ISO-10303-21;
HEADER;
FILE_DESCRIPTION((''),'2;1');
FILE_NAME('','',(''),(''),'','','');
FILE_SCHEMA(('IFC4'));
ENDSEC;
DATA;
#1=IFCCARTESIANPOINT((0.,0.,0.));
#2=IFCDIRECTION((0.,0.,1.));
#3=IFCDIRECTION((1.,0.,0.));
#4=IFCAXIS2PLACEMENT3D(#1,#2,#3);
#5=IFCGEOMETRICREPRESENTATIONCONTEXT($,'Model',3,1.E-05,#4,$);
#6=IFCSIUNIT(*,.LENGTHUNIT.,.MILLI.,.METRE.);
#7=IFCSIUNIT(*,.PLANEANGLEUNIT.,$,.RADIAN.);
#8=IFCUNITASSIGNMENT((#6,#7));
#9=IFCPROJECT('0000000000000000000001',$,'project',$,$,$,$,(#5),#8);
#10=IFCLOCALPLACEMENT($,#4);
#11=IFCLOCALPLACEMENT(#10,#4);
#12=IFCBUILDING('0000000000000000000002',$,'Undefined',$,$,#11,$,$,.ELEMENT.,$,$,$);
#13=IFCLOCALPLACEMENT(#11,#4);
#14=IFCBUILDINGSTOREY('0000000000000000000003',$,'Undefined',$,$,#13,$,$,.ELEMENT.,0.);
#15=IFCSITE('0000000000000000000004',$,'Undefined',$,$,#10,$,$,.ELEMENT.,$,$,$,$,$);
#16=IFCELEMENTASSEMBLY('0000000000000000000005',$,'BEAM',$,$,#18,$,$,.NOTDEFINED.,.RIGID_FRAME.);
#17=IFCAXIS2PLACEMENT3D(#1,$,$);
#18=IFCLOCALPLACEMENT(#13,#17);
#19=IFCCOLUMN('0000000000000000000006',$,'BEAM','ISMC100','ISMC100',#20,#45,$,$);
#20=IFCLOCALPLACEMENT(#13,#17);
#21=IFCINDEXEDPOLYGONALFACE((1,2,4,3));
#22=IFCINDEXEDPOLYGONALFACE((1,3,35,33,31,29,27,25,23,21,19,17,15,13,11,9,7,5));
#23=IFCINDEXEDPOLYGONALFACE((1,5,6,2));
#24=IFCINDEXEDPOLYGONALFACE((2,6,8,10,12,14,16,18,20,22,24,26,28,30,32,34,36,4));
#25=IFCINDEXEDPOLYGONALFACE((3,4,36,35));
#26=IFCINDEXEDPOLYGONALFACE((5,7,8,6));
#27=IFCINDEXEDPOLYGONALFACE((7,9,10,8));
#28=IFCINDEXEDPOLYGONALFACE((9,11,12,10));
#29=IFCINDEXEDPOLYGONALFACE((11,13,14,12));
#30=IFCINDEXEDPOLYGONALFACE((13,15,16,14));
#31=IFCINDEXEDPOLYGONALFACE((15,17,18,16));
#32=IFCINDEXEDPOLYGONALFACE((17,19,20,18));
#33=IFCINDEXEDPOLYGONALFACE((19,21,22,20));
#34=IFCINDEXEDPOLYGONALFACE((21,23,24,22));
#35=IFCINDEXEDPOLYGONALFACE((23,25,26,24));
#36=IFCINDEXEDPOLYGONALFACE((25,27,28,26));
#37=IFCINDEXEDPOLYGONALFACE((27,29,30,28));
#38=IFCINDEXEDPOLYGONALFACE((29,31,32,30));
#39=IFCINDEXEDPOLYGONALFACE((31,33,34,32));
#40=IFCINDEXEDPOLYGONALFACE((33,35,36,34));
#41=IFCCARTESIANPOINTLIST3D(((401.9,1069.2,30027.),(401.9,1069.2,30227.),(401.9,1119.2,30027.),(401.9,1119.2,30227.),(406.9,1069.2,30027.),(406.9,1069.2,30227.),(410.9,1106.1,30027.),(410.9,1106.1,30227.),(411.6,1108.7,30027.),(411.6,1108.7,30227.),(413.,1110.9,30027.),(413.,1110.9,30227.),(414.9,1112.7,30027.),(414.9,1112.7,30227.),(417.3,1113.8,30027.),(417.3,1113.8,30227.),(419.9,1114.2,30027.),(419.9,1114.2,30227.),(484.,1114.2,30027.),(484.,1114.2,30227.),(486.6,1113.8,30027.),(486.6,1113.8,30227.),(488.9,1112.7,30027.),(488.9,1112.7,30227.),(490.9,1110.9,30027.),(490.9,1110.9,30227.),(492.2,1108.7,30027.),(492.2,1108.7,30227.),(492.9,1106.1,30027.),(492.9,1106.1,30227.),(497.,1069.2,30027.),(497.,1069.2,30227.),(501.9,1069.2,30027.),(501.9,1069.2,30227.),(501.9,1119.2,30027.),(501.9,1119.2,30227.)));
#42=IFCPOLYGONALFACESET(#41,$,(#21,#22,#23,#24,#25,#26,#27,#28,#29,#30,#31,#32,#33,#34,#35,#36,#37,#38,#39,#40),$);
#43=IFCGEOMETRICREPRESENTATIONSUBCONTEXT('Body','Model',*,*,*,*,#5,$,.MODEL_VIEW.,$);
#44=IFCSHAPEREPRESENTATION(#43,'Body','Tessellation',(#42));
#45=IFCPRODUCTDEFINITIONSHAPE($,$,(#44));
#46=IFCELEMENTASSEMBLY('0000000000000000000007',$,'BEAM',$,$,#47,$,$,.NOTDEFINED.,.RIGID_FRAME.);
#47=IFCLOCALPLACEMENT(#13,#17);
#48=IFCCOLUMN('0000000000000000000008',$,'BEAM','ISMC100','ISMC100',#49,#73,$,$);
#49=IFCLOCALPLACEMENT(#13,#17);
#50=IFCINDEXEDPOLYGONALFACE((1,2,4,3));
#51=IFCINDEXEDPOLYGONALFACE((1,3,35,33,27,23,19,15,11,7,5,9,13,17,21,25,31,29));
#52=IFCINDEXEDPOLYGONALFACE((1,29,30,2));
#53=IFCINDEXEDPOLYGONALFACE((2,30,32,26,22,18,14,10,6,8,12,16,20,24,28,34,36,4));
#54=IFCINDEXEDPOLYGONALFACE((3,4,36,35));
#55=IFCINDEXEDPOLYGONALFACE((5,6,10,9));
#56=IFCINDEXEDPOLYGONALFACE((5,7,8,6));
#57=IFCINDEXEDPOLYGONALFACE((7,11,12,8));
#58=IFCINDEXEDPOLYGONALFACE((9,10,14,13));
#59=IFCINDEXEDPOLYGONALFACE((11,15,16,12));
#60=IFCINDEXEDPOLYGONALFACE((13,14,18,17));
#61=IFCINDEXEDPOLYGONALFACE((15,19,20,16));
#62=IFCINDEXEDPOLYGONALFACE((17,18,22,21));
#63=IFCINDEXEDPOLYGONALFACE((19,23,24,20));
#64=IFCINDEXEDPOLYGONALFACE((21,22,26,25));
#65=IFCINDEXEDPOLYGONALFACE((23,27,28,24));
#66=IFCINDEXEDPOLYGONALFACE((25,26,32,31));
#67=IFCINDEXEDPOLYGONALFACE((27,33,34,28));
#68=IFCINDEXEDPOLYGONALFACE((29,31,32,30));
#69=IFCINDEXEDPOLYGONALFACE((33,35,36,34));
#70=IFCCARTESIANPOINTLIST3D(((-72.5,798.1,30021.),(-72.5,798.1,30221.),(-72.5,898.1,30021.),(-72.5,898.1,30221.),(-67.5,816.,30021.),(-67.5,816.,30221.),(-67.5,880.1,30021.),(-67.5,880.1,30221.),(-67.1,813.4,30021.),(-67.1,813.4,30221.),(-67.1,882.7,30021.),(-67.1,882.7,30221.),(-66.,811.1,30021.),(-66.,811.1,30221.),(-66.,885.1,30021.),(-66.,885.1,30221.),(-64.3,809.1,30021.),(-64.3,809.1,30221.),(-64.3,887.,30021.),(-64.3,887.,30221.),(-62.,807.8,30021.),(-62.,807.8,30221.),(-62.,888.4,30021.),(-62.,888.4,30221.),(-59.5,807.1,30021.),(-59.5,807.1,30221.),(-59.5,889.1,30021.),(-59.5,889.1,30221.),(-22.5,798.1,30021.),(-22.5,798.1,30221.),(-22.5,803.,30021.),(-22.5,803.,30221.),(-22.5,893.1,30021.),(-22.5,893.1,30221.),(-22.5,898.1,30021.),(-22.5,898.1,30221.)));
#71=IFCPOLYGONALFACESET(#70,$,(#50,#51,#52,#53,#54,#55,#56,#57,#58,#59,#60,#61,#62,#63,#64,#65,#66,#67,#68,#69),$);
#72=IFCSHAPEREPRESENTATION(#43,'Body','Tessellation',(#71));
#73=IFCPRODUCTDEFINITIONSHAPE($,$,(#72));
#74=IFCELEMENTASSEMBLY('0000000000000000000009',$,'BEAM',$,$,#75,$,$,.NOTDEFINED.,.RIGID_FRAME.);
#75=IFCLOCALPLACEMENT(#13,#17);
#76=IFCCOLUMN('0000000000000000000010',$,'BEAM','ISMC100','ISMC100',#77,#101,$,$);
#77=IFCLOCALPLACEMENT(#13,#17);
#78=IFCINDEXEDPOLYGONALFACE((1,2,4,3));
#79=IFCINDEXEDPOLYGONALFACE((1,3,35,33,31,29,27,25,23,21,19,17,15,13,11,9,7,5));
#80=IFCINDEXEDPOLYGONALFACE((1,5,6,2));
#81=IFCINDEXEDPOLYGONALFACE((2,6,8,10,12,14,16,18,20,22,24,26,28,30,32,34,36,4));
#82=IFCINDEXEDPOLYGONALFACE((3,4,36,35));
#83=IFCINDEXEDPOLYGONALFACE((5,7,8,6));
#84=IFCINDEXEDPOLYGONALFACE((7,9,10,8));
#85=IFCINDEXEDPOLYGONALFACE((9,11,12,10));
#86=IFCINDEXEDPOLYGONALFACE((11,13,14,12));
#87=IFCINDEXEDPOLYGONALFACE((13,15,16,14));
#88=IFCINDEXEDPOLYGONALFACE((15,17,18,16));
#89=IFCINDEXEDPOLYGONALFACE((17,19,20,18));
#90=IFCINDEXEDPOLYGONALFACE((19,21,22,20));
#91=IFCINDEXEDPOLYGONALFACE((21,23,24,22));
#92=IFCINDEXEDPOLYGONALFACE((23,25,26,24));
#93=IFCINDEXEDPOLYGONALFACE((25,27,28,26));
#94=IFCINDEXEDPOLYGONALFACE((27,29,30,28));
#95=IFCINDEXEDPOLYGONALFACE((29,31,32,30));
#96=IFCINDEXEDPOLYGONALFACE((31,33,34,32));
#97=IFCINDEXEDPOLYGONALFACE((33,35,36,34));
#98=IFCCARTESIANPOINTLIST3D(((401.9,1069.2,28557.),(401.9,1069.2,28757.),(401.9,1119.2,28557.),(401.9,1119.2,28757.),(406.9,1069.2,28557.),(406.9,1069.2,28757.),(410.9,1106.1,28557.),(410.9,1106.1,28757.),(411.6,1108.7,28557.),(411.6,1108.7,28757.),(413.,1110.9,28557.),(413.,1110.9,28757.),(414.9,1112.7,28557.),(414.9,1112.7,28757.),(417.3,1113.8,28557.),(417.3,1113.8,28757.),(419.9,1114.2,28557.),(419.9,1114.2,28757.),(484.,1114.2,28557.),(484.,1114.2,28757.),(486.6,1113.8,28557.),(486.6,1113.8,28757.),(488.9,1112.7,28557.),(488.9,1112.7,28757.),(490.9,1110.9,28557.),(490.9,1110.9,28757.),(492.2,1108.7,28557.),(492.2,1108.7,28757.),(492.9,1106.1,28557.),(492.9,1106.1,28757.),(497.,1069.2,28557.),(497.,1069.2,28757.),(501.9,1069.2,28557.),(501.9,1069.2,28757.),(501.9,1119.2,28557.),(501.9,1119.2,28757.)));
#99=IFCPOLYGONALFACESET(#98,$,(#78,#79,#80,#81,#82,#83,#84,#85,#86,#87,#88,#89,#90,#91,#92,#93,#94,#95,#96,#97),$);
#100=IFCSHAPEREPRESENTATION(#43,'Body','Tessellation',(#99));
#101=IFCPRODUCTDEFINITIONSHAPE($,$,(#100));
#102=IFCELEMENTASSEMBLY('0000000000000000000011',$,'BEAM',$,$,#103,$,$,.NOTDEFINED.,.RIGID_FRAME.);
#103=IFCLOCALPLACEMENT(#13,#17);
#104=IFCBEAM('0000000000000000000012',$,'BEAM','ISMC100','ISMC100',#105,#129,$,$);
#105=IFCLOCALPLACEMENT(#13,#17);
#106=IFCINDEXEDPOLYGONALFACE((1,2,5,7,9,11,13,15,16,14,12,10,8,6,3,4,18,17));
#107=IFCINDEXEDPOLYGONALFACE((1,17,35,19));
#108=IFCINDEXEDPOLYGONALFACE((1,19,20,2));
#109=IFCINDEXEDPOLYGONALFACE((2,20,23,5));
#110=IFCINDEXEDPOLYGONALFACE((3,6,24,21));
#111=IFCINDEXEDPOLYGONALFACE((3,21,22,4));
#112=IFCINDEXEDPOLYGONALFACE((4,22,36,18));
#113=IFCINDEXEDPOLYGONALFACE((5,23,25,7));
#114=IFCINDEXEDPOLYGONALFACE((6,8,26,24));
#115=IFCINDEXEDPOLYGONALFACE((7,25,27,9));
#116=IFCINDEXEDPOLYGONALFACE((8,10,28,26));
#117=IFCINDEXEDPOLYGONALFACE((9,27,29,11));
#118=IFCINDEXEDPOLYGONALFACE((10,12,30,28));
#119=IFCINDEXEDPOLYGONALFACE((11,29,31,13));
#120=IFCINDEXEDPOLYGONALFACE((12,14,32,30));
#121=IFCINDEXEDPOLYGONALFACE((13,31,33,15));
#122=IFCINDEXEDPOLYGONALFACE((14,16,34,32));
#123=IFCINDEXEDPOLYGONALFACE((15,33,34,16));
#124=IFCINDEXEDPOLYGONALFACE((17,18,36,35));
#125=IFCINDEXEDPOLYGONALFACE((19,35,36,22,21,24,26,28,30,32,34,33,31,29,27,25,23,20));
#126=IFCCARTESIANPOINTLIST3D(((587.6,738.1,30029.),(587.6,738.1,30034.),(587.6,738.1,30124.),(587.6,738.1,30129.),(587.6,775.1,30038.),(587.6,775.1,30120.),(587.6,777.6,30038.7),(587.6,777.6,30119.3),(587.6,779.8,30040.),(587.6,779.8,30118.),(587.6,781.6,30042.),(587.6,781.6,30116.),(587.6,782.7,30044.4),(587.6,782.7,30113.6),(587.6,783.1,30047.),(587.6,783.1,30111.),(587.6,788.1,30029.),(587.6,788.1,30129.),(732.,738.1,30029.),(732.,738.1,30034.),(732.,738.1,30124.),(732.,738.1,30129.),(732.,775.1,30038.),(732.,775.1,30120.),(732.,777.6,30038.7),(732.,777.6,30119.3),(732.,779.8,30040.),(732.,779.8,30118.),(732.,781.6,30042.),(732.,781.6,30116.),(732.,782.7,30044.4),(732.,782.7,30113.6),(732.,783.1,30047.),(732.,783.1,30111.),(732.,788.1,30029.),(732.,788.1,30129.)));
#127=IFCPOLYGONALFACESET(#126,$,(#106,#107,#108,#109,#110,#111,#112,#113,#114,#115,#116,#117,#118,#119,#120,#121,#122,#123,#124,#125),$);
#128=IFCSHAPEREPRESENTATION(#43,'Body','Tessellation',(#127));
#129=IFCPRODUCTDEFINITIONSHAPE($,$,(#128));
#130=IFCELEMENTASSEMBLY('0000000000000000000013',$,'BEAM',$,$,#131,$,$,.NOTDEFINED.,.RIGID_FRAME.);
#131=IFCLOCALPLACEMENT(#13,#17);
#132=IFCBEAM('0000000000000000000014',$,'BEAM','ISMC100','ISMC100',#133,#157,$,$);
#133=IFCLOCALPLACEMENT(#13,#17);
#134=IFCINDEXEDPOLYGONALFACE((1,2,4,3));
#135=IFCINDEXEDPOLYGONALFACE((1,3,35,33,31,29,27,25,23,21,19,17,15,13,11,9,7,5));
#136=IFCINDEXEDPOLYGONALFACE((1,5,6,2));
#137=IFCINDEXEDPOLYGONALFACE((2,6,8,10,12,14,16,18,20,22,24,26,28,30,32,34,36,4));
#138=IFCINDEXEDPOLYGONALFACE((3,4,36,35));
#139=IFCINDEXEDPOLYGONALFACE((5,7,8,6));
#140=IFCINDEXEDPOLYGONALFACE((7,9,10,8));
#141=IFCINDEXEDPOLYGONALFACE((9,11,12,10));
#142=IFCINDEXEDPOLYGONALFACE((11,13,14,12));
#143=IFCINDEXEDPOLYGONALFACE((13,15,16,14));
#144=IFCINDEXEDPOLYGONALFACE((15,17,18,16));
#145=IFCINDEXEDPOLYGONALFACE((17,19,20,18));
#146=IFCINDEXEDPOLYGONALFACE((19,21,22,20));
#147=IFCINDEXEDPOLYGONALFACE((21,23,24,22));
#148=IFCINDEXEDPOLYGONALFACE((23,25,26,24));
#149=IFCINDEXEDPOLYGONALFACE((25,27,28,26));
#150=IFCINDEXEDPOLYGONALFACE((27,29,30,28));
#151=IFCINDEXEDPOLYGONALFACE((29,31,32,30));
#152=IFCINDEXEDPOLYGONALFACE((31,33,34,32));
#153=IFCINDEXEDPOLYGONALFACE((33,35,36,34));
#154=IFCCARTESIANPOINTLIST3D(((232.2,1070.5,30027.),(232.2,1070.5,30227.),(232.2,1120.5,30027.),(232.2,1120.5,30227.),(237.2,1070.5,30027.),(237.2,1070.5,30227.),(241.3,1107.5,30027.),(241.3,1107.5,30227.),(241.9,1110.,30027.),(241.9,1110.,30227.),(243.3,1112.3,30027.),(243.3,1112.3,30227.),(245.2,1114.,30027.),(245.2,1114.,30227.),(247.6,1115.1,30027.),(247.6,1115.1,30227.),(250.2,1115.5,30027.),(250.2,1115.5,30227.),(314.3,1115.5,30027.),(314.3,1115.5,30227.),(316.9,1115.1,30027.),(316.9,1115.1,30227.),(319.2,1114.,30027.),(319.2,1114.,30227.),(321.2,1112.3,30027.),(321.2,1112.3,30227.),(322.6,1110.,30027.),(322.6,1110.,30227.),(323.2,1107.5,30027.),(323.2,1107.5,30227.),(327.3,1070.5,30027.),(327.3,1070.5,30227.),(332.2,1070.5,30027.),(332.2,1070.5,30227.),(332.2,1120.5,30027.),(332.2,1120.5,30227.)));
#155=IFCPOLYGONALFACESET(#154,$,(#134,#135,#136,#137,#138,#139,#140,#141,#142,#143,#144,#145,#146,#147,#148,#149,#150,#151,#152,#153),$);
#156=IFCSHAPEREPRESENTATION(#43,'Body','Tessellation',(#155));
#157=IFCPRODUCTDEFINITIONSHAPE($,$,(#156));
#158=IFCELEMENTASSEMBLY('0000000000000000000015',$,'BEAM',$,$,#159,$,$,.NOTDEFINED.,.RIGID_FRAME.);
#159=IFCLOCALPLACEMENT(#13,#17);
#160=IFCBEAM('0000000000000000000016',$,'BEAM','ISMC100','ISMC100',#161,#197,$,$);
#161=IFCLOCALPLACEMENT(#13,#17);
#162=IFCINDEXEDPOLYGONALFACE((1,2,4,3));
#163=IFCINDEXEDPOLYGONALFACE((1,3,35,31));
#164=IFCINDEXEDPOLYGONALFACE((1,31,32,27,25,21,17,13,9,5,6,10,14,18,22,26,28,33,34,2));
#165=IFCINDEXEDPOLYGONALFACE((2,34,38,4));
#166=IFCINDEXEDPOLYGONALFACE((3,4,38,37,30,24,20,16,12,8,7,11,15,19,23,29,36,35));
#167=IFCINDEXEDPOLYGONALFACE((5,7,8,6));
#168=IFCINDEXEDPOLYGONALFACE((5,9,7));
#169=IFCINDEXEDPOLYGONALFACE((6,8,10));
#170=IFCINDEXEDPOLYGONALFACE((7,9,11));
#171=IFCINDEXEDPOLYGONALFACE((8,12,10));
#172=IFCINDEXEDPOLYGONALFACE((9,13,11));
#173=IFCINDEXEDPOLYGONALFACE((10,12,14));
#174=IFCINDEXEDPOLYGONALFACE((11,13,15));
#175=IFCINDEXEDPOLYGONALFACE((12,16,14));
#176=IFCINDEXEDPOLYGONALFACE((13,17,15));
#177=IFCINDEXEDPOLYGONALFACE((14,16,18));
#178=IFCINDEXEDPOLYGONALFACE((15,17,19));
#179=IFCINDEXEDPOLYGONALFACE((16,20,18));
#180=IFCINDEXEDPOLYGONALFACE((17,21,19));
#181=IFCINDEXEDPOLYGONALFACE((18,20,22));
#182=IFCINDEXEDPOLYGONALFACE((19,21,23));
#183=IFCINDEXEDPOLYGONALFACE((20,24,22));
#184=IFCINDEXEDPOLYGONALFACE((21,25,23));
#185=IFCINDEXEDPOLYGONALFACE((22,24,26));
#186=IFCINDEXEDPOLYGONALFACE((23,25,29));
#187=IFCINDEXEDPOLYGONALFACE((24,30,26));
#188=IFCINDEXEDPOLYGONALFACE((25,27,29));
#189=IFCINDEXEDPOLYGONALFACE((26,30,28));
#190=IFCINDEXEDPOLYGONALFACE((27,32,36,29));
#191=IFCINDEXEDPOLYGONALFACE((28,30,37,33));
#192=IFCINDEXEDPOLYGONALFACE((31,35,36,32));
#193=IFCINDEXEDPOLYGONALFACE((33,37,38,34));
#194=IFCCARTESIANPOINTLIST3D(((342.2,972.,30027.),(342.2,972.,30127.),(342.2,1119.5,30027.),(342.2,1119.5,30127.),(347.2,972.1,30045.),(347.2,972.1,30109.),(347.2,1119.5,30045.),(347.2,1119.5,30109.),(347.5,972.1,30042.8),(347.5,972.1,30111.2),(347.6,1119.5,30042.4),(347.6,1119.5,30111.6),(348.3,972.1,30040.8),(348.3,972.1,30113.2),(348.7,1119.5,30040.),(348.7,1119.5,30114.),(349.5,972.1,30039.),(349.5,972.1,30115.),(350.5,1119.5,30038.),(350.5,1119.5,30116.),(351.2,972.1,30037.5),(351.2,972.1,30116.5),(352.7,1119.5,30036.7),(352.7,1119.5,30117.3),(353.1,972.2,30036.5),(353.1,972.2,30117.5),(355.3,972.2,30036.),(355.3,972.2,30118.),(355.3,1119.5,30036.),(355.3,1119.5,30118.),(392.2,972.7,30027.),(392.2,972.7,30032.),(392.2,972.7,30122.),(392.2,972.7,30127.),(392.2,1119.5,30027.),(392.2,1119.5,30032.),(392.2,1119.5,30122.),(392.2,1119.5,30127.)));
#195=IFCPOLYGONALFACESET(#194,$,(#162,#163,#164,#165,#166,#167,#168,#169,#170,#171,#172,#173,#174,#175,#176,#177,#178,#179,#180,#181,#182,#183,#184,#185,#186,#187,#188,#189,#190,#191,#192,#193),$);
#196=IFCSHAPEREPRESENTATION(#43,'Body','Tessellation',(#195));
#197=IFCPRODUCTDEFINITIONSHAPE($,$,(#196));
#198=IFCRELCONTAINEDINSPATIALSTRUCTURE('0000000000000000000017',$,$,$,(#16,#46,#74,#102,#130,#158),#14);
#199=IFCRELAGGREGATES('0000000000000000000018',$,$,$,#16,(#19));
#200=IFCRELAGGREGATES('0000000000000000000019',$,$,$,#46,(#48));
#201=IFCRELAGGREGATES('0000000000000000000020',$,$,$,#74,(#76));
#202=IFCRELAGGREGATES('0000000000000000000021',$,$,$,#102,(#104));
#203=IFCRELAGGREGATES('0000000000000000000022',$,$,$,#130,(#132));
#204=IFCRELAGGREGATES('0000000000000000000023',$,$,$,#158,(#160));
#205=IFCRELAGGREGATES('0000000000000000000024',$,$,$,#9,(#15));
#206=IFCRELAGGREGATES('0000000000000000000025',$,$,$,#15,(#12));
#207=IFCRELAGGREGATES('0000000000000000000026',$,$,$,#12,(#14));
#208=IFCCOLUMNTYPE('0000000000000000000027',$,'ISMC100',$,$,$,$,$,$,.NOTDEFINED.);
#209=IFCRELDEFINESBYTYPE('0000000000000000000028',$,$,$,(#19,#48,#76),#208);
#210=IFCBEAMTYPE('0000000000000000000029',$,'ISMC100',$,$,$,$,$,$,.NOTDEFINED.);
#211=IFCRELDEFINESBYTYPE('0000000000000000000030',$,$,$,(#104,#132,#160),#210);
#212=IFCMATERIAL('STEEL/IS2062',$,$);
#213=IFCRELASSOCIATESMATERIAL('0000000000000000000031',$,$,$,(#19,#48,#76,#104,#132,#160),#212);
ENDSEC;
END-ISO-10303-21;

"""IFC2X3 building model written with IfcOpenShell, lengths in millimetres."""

from ifc_helpers import new_model, si_unit, frame, origin_with_axes, origin_2d_with_axis, place, context, subcontext, project, spatial, u_section, extrude, clip, halfspace, material, type_object, element, aggregate, save


model = new_model("IFC2X3")

# Units and contexts
model_context = context("Model", 3, precision=1e-05, world=origin_with_axes())
body_context = subcontext(model_context, "Body", "Model", "MODEL_VIEW")
ifc_project = project(units=[si_unit("LENGTHUNIT", "METRE", prefix="MILLI"), si_unit("PLANEANGLEUNIT", "RADIAN")], contexts=[model_context])

# Site, building, storey
site_placement = place(None, origin_with_axes())
site = spatial("IfcSite", under=ifc_project, at=site_placement, Name="Undefined", CompositionType="ELEMENT")
building_placement = place(site_placement, origin_with_axes())
building = spatial("IfcBuilding", under=site, at=building_placement, Name="Undefined", CompositionType="ELEMENT")
storey_placement = place(building_placement, origin_with_axes())
storey = spatial("IfcBuildingStorey", under=building, at=storey_placement, Name="Undefined", CompositionType="ELEMENT", Elevation=0.0)

# Element assemblies, columns
assembly_1_placement = place(storey_placement, origin_with_axes())
assembly_1 = element("IfcElementAssembly", 1, at=assembly_1_placement, inside=storey, Name="BEAM", AssemblyPlace="NOTDEFINED", PredefinedType="RIGID_FRAME")
ifc_material = material(Name="STEEL/IS2062")
column_type_1 = type_object("IfcColumnType", Name="ISMC100", PredefinedType="NOTDEFINED")
column_1_placement = place(assembly_1_placement, frame((451.9, 1094.2, 30027.0), z_axis=(0.0, 0.0, 1.0), x_axis=(-1.0, 0.0, 0.0)))
column_1 = element("IfcColumn", 2, at=column_1_placement, type_object=column_type_1, material=ifc_material, Name="BEAM", Description="ISMC100", ObjectType="ISMC100", context=body_context, shape_type="SweptSolid", body=[
    extrude(u_section(Depth=100.0, FlangeWidth=50.0, WebThickness=5.0, FlangeThickness=7.7, FilletRadius=9.0, FlangeSlope=0.10956, at=origin_2d_with_axis()), frame((0.0, 0.0, 200.0), z_axis=(0.0, 0.0, -1.0), x_axis=(0.0, 1.0, 0.0)), (0.0, 0.0, 1.0), 200.0),
])
aggregate(assembly_1, [column_1])
assembly_2_placement = place(storey_placement, origin_with_axes())
assembly_2 = element("IfcElementAssembly", 3, at=assembly_2_placement, inside=storey, Name="BEAM", AssemblyPlace="NOTDEFINED", PredefinedType="RIGID_FRAME")
column_2_placement = place(assembly_2_placement, frame((-47.5, 848.1, 30021.0), z_axis=(0.0, 0.0, 1.0), x_axis=(0.0, -1.0, 0.0)))
column_2 = element("IfcColumn", 4, at=column_2_placement, type_object=column_type_1, material=ifc_material, Name="BEAM", Description="ISMC100", ObjectType="ISMC100", context=body_context, shape_type="SweptSolid", body=[
    extrude(u_section(Depth=100.0, FlangeWidth=50.0, WebThickness=5.0, FlangeThickness=7.7, FilletRadius=9.0, FlangeSlope=0.10956, at=origin_2d_with_axis()), frame((0.0, 0.0, 200.0), z_axis=(0.0, 0.0, -1.0), x_axis=(0.0, 1.0, 0.0)), (0.0, 0.0, 1.0), 200.0),
])
aggregate(assembly_2, [column_2])
assembly_3_placement = place(storey_placement, origin_with_axes())
assembly_3 = element("IfcElementAssembly", 5, at=assembly_3_placement, inside=storey, Name="BEAM", AssemblyPlace="NOTDEFINED", PredefinedType="RIGID_FRAME")
column_3_placement = place(assembly_3_placement, frame((451.9, 1094.2, 28557.0), z_axis=(0.0, 0.0, 1.0), x_axis=(-1.0, 0.0, 0.0)))
column_3 = element("IfcColumn", 6, at=column_3_placement, type_object=column_type_1, material=ifc_material, Name="BEAM", Description="ISMC100", ObjectType="ISMC100", context=body_context, shape_type="SweptSolid", body=[
    extrude(u_section(Depth=100.0, FlangeWidth=50.0, WebThickness=5.0, FlangeThickness=7.7, FilletRadius=9.0, FlangeSlope=0.10956, at=origin_2d_with_axis()), frame((0.0, 0.0, 200.0), z_axis=(0.0, 0.0, -1.0), x_axis=(0.0, 1.0, 0.0)), (0.0, 0.0, 1.0), 200.0),
])
aggregate(assembly_3, [column_3])

# Element assemblies, beams
assembly_4_placement = place(storey_placement, origin_with_axes())
assembly_4 = element("IfcElementAssembly", 7, at=assembly_4_placement, inside=storey, Name="BEAM", AssemblyPlace="NOTDEFINED", PredefinedType="RIGID_FRAME")
beam_type_1 = type_object("IfcBeamType", Name="ISMC100", PredefinedType="NOTDEFINED")
beam_1_placement = place(assembly_4_placement, frame((732.0, 763.1, 30079.0), z_axis=(0.0, 0.0, -1.0), x_axis=(-1.0, 0.0, 0.0)))
beam_1 = element("IfcBeam", 8, at=beam_1_placement, type_object=beam_type_1, material=ifc_material, Name="BEAM", Description="ISMC100", ObjectType="ISMC100", context=body_context, shape_type="SweptSolid", body=[
    extrude(u_section(Depth=100.0, FlangeWidth=50.0, WebThickness=5.0, FlangeThickness=7.7, FilletRadius=9.0, FlangeSlope=0.10956, at=origin_2d_with_axis()), frame((144.4, 0.0, 0.0), z_axis=(-1.0, 0.0, 0.0), x_axis=(0.0, -1.0, 0.0)), (0.0, 0.0, 1.0), 144.4),
])
aggregate(assembly_4, [beam_1])
assembly_5_placement = place(storey_placement, origin_with_axes())
assembly_5 = element("IfcElementAssembly", 9, at=assembly_5_placement, inside=storey, Name="BEAM", AssemblyPlace="NOTDEFINED", PredefinedType="RIGID_FRAME")
beam_2_placement = place(assembly_5_placement, frame((282.2, 1095.5, 30227.0), z_axis=(1.0, 0.0, 0.0), x_axis=(0.0, 0.0, -1.0)))
beam_2 = element("IfcBeam", 10, at=beam_2_placement, type_object=beam_type_1, material=ifc_material, Name="BEAM", Description="ISMC100", ObjectType="ISMC100", context=body_context, shape_type="SweptSolid", body=[
    extrude(u_section(Depth=100.0, FlangeWidth=50.0, WebThickness=5.0, FlangeThickness=7.7, FilletRadius=9.0, FlangeSlope=0.10956, at=origin_2d_with_axis()), frame((200.0, 0.0, 0.0), z_axis=(-1.0, 0.0, 0.0), x_axis=(0.0, -1.0, 0.0)), (0.0, 0.0, 1.0), 200.0),
])
aggregate(assembly_5, [beam_2])
assembly_6_placement = place(storey_placement, origin_with_axes())
assembly_6 = element("IfcElementAssembly", 11, at=assembly_6_placement, inside=storey, Name="BEAM", AssemblyPlace="NOTDEFINED", PredefinedType="RIGID_FRAME")
beam_3_placement = place(assembly_6_placement, frame((367.2, 1119.5, 30077.0), z_axis=(0.0, 0.0, -1.0), x_axis=(0.0, -1.0, 0.0)))
beam_3 = element("IfcBeam", 12, at=beam_3_placement, type_object=beam_type_1, material=ifc_material, Name="BEAM", Description="ISMC100", ObjectType="ISMC100", context=body_context, shape_type="Clipping", body=[
    clip(extrude(u_section(Depth=100.0, FlangeWidth=50.0, WebThickness=5.0, FlangeThickness=7.7, FilletRadius=9.0, FlangeSlope=0.10956, at=origin_2d_with_axis()), frame((147.5, 0.0, 0.0), z_axis=(-1.0, 0.0, 0.0), x_axis=(0.0, -1.0, 0.0)), (0.0, 0.0, 1.0), 147.5), halfspace(frame((147.5, 25.0, -50.0), z_axis=(0.999902, -0.013997, 0.0), x_axis=(-0.013997, -0.999902, 0.0)), False)),
])
aggregate(assembly_6, [beam_3])

save(model, "model.ifc")
